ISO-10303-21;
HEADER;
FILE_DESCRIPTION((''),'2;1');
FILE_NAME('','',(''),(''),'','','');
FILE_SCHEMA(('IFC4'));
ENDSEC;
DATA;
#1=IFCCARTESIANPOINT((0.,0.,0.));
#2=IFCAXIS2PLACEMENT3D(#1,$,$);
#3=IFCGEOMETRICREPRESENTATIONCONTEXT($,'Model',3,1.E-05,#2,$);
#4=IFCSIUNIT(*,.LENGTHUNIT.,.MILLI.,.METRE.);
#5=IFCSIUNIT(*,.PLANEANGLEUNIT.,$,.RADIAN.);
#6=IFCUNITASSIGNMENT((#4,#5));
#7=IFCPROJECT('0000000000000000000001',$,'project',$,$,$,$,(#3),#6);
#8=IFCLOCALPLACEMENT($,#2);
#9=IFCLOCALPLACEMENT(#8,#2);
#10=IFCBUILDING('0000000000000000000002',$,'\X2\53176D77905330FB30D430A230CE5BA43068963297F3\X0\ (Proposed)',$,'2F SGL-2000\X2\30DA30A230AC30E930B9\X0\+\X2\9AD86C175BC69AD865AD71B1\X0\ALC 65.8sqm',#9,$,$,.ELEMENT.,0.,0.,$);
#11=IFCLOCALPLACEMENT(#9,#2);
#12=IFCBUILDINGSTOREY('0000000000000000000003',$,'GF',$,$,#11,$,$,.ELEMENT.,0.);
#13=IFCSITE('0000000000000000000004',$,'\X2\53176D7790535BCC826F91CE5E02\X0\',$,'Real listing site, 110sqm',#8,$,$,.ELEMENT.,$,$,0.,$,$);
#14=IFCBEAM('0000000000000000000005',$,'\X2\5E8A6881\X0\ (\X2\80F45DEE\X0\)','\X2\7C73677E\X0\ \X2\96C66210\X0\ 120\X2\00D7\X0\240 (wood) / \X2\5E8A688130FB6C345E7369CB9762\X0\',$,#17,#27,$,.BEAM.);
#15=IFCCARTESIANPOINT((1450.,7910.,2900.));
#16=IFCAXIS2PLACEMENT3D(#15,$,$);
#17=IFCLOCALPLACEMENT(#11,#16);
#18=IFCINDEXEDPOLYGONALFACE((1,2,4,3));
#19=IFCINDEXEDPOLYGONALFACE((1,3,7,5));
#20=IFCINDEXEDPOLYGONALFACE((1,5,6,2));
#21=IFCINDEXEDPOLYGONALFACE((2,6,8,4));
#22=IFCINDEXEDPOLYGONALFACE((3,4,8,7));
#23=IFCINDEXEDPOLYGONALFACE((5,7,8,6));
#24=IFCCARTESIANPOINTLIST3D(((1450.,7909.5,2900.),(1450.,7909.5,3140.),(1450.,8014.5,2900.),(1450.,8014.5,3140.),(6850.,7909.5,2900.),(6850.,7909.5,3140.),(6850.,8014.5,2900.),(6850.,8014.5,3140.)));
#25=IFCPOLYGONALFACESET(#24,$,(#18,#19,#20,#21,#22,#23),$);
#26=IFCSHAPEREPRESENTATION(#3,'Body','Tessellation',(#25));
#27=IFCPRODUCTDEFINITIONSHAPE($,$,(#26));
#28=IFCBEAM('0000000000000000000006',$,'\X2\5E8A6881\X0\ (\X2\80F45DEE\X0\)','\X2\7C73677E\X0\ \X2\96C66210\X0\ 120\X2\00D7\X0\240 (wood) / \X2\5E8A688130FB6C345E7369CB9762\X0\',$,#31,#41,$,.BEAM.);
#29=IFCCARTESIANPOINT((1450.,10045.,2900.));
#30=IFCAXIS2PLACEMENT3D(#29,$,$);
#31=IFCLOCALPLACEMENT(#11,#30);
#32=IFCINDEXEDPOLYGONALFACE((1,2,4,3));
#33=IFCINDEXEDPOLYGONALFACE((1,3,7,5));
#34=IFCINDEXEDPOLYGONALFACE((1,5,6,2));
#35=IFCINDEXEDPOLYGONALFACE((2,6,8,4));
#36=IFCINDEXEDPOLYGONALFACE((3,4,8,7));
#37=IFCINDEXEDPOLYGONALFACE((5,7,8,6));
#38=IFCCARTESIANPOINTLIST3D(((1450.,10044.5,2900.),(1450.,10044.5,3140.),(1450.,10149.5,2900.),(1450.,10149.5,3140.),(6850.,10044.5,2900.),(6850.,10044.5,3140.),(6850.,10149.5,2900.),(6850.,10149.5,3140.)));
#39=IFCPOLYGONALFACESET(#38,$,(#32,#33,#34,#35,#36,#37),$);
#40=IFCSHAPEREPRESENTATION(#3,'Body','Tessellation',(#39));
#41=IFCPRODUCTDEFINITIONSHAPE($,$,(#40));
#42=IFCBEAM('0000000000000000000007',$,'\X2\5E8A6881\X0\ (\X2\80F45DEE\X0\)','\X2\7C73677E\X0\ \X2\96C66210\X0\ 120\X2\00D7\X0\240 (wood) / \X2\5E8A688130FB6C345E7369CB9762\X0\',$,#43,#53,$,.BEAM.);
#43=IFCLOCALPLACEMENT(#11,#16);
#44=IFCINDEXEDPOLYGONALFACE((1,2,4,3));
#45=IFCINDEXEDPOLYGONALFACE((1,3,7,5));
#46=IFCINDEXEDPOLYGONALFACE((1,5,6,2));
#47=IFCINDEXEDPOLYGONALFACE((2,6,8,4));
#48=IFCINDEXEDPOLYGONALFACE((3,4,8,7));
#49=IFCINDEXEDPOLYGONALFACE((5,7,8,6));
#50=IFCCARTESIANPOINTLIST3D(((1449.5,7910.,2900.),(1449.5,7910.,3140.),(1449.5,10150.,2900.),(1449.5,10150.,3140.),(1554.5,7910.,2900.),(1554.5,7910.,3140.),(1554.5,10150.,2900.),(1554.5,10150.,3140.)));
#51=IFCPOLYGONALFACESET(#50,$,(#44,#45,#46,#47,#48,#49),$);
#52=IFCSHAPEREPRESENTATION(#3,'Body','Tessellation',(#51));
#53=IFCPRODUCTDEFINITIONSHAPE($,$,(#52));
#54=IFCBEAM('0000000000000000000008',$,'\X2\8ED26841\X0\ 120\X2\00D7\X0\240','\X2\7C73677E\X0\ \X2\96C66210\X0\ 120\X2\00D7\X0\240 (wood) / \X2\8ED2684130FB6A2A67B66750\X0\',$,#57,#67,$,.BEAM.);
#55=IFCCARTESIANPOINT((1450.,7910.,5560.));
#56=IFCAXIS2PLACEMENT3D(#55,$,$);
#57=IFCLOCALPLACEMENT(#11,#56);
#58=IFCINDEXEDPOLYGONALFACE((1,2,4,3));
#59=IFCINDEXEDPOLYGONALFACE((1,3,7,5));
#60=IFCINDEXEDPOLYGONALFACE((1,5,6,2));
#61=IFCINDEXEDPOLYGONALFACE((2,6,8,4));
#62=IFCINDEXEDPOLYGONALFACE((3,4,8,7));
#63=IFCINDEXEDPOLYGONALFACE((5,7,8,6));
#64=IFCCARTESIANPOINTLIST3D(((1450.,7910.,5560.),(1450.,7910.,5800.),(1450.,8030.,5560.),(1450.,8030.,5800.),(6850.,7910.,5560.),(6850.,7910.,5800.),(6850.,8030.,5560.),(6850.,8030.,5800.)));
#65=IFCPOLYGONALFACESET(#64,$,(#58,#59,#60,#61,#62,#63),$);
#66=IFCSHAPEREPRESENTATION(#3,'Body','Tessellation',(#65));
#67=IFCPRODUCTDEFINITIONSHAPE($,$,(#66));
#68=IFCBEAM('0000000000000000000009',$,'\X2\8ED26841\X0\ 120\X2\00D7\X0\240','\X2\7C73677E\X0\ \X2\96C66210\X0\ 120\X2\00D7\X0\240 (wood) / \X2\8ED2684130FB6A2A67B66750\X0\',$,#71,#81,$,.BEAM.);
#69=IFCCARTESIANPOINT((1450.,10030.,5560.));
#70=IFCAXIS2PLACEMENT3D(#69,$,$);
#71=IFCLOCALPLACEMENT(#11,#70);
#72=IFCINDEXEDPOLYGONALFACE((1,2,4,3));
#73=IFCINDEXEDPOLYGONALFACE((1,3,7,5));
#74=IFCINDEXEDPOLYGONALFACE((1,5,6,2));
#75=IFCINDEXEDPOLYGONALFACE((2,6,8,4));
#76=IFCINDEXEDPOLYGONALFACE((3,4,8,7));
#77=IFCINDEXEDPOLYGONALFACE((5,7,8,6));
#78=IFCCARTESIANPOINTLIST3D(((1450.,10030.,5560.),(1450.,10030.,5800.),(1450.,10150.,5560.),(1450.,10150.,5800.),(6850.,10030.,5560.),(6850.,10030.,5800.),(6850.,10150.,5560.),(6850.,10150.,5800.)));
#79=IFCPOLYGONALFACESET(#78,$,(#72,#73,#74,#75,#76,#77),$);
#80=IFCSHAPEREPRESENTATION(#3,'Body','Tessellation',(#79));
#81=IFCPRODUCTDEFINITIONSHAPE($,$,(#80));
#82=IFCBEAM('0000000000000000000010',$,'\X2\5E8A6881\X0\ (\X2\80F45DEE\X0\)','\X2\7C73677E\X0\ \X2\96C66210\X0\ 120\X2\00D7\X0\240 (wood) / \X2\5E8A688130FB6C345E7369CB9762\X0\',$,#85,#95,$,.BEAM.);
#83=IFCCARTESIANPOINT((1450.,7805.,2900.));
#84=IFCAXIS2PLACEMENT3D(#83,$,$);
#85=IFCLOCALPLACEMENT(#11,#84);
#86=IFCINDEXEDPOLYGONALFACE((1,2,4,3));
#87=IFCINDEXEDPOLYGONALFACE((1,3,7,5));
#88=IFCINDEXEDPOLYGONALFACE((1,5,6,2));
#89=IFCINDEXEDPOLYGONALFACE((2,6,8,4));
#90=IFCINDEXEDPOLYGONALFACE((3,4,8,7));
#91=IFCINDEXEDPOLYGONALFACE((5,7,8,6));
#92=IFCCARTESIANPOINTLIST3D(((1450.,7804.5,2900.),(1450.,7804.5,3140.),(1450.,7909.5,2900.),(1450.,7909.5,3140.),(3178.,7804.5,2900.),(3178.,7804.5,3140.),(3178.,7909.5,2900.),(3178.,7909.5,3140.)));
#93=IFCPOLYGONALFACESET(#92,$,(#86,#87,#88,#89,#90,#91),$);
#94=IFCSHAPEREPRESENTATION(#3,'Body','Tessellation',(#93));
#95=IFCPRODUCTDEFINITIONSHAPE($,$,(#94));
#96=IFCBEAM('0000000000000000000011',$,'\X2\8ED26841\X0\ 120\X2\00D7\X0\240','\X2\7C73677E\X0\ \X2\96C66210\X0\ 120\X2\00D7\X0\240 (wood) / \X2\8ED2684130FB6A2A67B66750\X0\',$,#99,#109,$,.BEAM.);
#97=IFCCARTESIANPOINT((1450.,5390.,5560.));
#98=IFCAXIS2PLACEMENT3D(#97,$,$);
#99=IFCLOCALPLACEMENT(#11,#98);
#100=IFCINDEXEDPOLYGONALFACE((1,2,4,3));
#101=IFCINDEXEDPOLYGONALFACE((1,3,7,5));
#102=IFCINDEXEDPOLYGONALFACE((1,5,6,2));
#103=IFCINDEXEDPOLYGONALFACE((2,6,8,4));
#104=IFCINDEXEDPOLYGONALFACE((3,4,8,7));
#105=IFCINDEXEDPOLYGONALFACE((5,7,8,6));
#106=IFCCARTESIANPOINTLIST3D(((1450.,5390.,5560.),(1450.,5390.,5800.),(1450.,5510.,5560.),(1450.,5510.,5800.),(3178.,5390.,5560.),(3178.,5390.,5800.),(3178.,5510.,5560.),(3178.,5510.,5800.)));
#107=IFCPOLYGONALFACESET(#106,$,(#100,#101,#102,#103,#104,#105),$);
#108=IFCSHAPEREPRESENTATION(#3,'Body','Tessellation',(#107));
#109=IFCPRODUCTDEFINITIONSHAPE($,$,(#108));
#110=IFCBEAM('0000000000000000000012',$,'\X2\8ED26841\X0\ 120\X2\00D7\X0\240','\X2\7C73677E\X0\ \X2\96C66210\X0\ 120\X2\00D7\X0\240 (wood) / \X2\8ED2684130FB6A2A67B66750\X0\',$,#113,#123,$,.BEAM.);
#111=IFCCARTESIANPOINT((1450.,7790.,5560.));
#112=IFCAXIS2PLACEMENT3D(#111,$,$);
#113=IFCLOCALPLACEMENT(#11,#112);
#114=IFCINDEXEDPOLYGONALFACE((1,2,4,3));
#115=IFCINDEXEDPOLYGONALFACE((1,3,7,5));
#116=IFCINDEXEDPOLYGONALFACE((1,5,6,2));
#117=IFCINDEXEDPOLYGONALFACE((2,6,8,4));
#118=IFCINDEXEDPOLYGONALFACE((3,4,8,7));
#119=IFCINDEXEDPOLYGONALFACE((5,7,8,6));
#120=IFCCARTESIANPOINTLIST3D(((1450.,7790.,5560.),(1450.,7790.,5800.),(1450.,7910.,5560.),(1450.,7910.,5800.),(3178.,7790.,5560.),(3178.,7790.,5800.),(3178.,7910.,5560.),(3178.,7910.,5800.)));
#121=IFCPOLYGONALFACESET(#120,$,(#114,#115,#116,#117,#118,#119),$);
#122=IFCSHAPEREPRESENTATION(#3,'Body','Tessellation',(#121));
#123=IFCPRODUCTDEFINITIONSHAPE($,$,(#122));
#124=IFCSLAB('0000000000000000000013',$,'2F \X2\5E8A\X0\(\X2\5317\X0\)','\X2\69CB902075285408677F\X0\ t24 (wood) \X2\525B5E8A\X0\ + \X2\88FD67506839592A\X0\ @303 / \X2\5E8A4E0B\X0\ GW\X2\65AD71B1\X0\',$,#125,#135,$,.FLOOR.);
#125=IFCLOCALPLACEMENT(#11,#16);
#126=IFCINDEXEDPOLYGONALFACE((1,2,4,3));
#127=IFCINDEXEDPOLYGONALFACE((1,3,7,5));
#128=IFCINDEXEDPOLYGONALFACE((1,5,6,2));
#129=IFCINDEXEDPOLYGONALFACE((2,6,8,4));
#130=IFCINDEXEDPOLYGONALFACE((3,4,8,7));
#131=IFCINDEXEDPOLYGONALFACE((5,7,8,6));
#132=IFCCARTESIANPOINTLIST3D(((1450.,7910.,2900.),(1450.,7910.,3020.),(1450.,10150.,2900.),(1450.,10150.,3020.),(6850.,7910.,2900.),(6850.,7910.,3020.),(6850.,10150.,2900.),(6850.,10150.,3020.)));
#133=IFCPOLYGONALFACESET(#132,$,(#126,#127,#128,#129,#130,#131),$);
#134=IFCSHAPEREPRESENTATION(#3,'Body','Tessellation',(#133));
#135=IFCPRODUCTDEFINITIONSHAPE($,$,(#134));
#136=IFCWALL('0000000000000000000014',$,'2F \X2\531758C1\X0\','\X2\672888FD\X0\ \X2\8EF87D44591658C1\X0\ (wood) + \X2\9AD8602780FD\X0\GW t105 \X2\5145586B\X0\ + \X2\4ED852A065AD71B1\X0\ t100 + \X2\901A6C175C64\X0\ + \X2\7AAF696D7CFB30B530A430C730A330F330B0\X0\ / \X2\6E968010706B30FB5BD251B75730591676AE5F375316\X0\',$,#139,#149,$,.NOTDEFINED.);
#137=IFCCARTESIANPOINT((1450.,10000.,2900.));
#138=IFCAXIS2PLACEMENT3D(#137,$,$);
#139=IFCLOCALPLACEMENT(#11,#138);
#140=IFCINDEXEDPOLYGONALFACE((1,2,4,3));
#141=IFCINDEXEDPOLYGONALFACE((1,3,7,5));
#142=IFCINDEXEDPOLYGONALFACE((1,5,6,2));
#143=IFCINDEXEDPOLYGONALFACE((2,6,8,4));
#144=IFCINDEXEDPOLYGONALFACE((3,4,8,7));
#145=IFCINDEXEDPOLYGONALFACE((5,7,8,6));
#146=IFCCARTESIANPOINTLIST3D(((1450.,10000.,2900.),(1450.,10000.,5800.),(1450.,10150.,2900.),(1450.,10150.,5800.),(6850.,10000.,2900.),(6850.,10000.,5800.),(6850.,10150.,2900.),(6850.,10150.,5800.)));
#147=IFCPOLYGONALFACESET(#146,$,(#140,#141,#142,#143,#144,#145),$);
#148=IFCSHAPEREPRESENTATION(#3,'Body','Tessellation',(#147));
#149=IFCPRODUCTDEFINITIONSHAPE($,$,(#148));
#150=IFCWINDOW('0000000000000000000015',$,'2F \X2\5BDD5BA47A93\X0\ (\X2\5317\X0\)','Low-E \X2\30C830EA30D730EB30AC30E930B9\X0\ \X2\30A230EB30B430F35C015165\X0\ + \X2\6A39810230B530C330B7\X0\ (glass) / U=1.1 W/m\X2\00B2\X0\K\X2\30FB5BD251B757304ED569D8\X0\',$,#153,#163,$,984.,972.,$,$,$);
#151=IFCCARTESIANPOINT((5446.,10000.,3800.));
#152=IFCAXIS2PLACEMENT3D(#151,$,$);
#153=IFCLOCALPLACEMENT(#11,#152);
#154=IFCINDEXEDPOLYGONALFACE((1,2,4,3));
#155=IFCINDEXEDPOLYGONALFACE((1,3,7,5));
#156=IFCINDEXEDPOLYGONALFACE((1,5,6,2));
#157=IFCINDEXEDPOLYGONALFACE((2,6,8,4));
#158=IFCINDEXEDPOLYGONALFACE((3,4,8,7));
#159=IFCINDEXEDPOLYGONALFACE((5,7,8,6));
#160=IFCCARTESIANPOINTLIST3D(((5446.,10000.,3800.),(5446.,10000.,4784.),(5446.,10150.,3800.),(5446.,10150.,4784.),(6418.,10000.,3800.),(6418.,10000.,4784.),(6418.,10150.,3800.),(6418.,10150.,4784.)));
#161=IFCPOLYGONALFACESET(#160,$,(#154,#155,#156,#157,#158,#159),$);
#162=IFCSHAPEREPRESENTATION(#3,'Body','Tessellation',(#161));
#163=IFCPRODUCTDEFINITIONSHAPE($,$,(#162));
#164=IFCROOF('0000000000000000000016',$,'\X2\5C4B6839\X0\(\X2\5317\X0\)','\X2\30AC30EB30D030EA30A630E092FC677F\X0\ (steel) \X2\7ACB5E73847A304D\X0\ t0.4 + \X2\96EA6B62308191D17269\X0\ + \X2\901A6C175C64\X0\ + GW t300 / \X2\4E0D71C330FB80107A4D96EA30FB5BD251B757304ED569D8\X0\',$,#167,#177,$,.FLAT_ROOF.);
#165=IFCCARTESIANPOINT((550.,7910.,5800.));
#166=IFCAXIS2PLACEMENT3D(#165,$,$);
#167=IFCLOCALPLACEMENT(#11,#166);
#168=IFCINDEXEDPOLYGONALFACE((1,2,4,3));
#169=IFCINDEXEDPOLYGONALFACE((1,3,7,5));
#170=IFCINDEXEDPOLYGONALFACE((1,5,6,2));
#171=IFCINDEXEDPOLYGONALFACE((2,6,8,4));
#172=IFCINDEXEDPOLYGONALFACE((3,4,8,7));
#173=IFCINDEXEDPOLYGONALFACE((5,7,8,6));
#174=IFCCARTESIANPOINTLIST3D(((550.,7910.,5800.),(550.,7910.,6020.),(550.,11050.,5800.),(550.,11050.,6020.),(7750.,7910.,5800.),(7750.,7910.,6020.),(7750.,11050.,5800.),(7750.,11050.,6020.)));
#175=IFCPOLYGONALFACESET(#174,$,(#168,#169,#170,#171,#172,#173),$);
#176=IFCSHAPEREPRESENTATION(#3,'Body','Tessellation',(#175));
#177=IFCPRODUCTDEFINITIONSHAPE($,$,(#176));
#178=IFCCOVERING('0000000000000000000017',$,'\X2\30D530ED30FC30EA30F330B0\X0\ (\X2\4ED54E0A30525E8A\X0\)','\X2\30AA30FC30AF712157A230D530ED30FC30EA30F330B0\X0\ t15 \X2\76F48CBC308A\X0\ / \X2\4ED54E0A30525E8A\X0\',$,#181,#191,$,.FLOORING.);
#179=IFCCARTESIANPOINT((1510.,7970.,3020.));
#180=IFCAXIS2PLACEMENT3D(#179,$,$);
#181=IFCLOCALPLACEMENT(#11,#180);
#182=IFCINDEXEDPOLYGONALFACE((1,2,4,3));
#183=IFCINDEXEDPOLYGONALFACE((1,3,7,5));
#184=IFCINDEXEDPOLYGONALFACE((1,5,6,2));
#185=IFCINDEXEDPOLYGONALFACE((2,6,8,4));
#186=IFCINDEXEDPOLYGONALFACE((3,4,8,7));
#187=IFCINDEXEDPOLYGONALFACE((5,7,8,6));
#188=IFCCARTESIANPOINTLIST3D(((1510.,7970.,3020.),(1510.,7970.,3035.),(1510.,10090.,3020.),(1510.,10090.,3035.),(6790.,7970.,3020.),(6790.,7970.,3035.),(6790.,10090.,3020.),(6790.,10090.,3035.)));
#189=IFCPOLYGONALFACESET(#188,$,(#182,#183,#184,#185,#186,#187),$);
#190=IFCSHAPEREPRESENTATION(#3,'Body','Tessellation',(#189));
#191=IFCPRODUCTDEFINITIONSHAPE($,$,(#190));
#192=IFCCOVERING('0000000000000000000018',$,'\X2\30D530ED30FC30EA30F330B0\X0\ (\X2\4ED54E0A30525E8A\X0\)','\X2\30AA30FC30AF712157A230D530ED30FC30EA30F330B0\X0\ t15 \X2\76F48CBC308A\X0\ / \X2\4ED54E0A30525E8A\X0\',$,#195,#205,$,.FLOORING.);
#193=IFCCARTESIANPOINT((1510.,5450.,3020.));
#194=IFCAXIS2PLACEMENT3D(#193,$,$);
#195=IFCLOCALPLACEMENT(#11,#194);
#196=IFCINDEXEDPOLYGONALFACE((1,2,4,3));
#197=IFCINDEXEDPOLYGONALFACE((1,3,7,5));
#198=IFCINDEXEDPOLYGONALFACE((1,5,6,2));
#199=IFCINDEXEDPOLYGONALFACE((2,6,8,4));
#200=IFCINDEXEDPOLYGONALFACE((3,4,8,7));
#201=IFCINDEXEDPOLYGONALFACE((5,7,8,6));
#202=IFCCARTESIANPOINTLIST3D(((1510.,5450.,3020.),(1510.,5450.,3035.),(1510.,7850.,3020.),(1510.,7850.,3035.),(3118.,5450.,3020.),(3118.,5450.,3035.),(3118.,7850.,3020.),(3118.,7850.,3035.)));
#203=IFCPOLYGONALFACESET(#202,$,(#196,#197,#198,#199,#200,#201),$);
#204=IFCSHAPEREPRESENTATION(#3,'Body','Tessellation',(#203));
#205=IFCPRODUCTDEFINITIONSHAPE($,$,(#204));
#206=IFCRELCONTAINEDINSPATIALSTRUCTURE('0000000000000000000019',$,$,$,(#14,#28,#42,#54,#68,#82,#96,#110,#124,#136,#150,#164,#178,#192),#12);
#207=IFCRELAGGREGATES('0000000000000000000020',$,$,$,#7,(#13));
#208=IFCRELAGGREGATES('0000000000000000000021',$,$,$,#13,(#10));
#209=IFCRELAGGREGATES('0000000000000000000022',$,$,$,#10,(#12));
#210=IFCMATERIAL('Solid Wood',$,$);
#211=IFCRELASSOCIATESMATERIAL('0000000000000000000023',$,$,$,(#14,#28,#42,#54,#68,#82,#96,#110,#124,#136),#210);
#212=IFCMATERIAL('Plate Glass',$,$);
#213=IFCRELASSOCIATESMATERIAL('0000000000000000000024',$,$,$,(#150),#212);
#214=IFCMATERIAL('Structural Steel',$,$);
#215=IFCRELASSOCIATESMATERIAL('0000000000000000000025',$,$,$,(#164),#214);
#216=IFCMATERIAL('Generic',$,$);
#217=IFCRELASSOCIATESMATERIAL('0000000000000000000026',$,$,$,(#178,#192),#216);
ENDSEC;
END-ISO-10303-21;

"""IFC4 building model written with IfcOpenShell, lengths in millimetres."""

from ifc_helpers import new_model, si_unit, frame, frame_2d, origin, place, context, project, spatial, rectangle, extrude, material, element, fill, save


model = new_model("IFC4")

# Units and contexts
model_context = context("Model", 3, precision=1e-05, world=origin())
ifc_project = project(units=[si_unit("LENGTHUNIT", "METRE", prefix="MILLI"), si_unit("PLANEANGLEUNIT", "RADIAN")], contexts=[model_context])

# Site, building, storey
site_placement = place(None, origin())
site = spatial("IfcSite", under=ifc_project, at=site_placement, Name="北海道富良野市", ObjectType="Real listing site, 110sqm", CompositionType="ELEMENT", RefElevation=0.0)
building_placement = place(site_placement, origin())
building = spatial("IfcBuilding", under=site, at=building_placement, Name="北海道・ピアノ室と防音 (Proposed)", ObjectType="2F SGL-2000ペアガラス+高気密高断熱ALC 65.8sqm", CompositionType="ELEMENT", ElevationOfRefHeight=0.0, ElevationOfTerrain=0.0)
storey_placement = place(building_placement, origin())
storey = spatial("IfcBuildingStorey", under=building, at=storey_placement, Name="GF", CompositionType="ELEMENT", Elevation=0.0)

# Shared definitions
ifc_material_1 = material(Name="Solid Wood")

# Beams
beam_1_placement = place(storey_placement, frame((1450.0, 7910.0, 2900.0)))
element("IfcBeam", 1, at=beam_1_placement, inside=storey, material=ifc_material_1, Name="床梁 (胴差)", Description="米松 集成 120×240 (wood) / 床梁・水平構面", PredefinedType="BEAM", context=model_context, shape_type="SweptSolid", body=[
    extrude(rectangle(XDim=5400.0, YDim=105.0, at=frame_2d((2700.0, 52.0))), frame((1450.0, 7910.0, 2900.0)), (0.0, 0.0, 1.0), 240.0),
])
beam_2_placement = place(storey_placement, frame((1450.0, 10045.0, 2900.0)))
element("IfcBeam", 2, at=beam_2_placement, inside=storey, material=ifc_material_1, Name="床梁 (胴差)", Description="米松 集成 120×240 (wood) / 床梁・水平構面", PredefinedType="BEAM", context=model_context, shape_type="SweptSolid", body=[
    extrude(rectangle(XDim=5400.0, YDim=105.0, at=frame_2d((2700.0, 52.0))), frame((1450.0, 10045.0, 2900.0)), (0.0, 0.0, 1.0), 240.0),
])
beam_3_placement = place(storey_placement, frame((1450.0, 7910.0, 2900.0)))
element("IfcBeam", 3, at=beam_3_placement, inside=storey, material=ifc_material_1, Name="床梁 (胴差)", Description="米松 集成 120×240 (wood) / 床梁・水平構面", PredefinedType="BEAM", context=model_context, shape_type="SweptSolid", body=[
    extrude(rectangle(XDim=105.0, YDim=2240.0, at=frame_2d((52.0, 1120.0))), frame((1450.0, 7910.0, 2900.0)), (0.0, 0.0, 1.0), 240.0),
])
beam_4_placement = place(storey_placement, frame((1450.0, 7910.0, 5560.0)))
element("IfcBeam", 4, at=beam_4_placement, inside=storey, material=ifc_material_1, Name="軒桁 120×240", Description="米松 集成 120×240 (wood) / 軒桁・横架材", PredefinedType="BEAM", context=model_context, shape_type="SweptSolid", body=[
    extrude(rectangle(XDim=5400.0, YDim=120.0, at=frame_2d((2700.0, 60.0))), frame((1450.0, 7910.0, 5560.0)), (0.0, 0.0, 1.0), 240.0),
])
beam_5_placement = place(storey_placement, frame((1450.0, 10030.0, 5560.0)))
element("IfcBeam", 5, at=beam_5_placement, inside=storey, material=ifc_material_1, Name="軒桁 120×240", Description="米松 集成 120×240 (wood) / 軒桁・横架材", PredefinedType="BEAM", context=model_context, shape_type="SweptSolid", body=[
    extrude(rectangle(XDim=5400.0, YDim=120.0, at=frame_2d((2700.0, 60.0))), frame((1450.0, 10030.0, 5560.0)), (0.0, 0.0, 1.0), 240.0),
])
beam_6_placement = place(storey_placement, frame((1450.0, 7805.0, 2900.0)))
element("IfcBeam", 6, at=beam_6_placement, inside=storey, material=ifc_material_1, Name="床梁 (胴差)", Description="米松 集成 120×240 (wood) / 床梁・水平構面", PredefinedType="BEAM", context=model_context, shape_type="SweptSolid", body=[
    extrude(rectangle(XDim=1728.0, YDim=105.0, at=frame_2d((864.0, 52.0))), frame((1450.0, 7805.0, 2900.0)), (0.0, 0.0, 1.0), 240.0),
])
beam_7_placement = place(storey_placement, frame((1450.0, 5390.0, 5560.0)))
element("IfcBeam", 7, at=beam_7_placement, inside=storey, material=ifc_material_1, Name="軒桁 120×240", Description="米松 集成 120×240 (wood) / 軒桁・横架材", PredefinedType="BEAM", context=model_context, shape_type="SweptSolid", body=[
    extrude(rectangle(XDim=1728.0, YDim=120.0, at=frame_2d((864.0, 60.0))), frame((1450.0, 5390.0, 5560.0)), (0.0, 0.0, 1.0), 240.0),
])
beam_8_placement = place(storey_placement, frame((1450.0, 7790.0, 5560.0)))
element("IfcBeam", 8, at=beam_8_placement, inside=storey, material=ifc_material_1, Name="軒桁 120×240", Description="米松 集成 120×240 (wood) / 軒桁・横架材", PredefinedType="BEAM", context=model_context, shape_type="SweptSolid", body=[
    extrude(rectangle(XDim=1728.0, YDim=120.0, at=frame_2d((864.0, 60.0))), frame((1450.0, 7790.0, 5560.0)), (0.0, 0.0, 1.0), 240.0),
])

# Slab
slab_placement = place(storey_placement, frame((1450.0, 7910.0, 2900.0)))
element("IfcSlab", 9, at=slab_placement, inside=storey, material=ifc_material_1, Name="2F 床(北)", Description="構造用合板 t24 (wood) 剛床 + 製材根太 @303 / 床下 GW断熱", PredefinedType="FLOOR", context=model_context, shape_type="SweptSolid", body=[
    extrude(rectangle(XDim=5400.0, YDim=2240.0, at=frame_2d((2700.0, 1120.0))), frame((1450.0, 7910.0, 2900.0)), (0.0, 0.0, 1.0), 120.0),
])

# Wall, opening, window
wall_placement = place(storey_placement, frame((1450.0, 10000.0, 2900.0)))
wall = element("IfcWall", 10, at=wall_placement, inside=storey, material=ifc_material_1, Name="2F 北壁", Description="木製 軸組外壁 (wood) + 高性能GW t105 充填 + 付加断熱 t100 + 通気層 + 窯業系サイディング / 準耐火・寒冷地外皮強化", PredefinedType="NOTDEFINED", context=model_context, shape_type="SweptSolid", body=[
    extrude(rectangle(XDim=5400.0, YDim=150.0, at=frame_2d((2700.0, 75.0))), frame((1450.0, 10000.0, 2900.0)), (0.0, 0.0, 1.0), 2900.0),
])
opening_placement = place(storey_placement, frame((5446.0, 10000.0, 3800.0)))
opening = element("IfcOpeningElement", 11, at=opening_placement, cuts=wall, PredefinedType="NOTDEFINED", context=model_context, shape_type="SweptSolid", body=[
    extrude(rectangle(XDim=972.0, YDim=150.0, at=frame_2d((486.0, 75.0))), frame((5446.0, 10000.0, 3800.0)), (0.0, 0.0, 1.0), 984.0),
])
ifc_material_2 = material(Name="Plate Glass")
window_placement = place(storey_placement, frame((5446.0, 10000.0, 3800.0)))
window = element("IfcWindow", 12, at=window_placement, inside=storey, material=ifc_material_2, Name="2F 寝室窓 (北)", Description="Low-E トリプルガラス アルゴン封入 + 樹脂サッシ (glass) / U=1.1 W/m²K・寒冷地仕様", OverallHeight=984.0, OverallWidth=972.0, context=model_context, shape_type="SweptSolid", body=[
    extrude(rectangle(XDim=972.0, YDim=150.0, at=frame_2d((486.0, 75.0))), frame((5446.0, 10000.0, 3800.0)), (0.0, 0.0, 1.0), 984.0),
])
fill(opening, window)

# Roof
ifc_material_3 = material(Name="Structural Steel")
for number, where, name in (
    (13, (550.0, 7910.0, 5800.0), "屋根(北)"),
):
    element("IfcRoof", number, at=place(storey_placement, frame(where)), inside=storey, material=ifc_material_3, Name=name, Description="ガルバリウム鋼板 (steel) 立平葺き t0.4 + 雪止め金物 + 通気層 + GW t300 / 不燃・耐積雪・寒冷地仕様", PredefinedType="FLAT_ROOF", context=model_context, shape_type="SweptSolid", body=[
        extrude(rectangle(XDim=7200.0, YDim=3140.0, at=frame_2d((3600.0, 1570.0))), frame((550.0, 7910.0, 5800.0)), (0.0, 0.0, 1.0), 220.0),
    ])

# Coverings
ifc_material_4 = material(Name="Generic")
covering_1_placement = place(storey_placement, frame((1510.0, 7970.0, 3020.0)))
element("IfcCovering", 14, at=covering_1_placement, inside=storey, material=ifc_material_4, Name="フローリング (仕上げ床)", Description="オーク無垢フローリング t15 直貼り / 仕上げ床", PredefinedType="FLOORING", context=model_context, shape_type="SweptSolid", body=[
    extrude(rectangle(XDim=5280.0, YDim=2120.0, at=frame_2d((2640.0, 1060.0))), frame((1510.0, 7970.0, 3020.0)), (0.0, 0.0, 1.0), 15.0),
])
covering_2_placement = place(storey_placement, frame((1510.0, 5450.0, 3020.0)))
element("IfcCovering", 15, at=covering_2_placement, inside=storey, material=ifc_material_4, Name="フローリング (仕上げ床)", Description="オーク無垢フローリング t15 直貼り / 仕上げ床", PredefinedType="FLOORING", context=model_context, shape_type="SweptSolid", body=[
    extrude(rectangle(XDim=1608.0, YDim=2400.0, at=frame_2d((804.0, 1200.0))), frame((1510.0, 5450.0, 3020.0)), (0.0, 0.0, 1.0), 15.0),
])

save(model, "model.ifc")
